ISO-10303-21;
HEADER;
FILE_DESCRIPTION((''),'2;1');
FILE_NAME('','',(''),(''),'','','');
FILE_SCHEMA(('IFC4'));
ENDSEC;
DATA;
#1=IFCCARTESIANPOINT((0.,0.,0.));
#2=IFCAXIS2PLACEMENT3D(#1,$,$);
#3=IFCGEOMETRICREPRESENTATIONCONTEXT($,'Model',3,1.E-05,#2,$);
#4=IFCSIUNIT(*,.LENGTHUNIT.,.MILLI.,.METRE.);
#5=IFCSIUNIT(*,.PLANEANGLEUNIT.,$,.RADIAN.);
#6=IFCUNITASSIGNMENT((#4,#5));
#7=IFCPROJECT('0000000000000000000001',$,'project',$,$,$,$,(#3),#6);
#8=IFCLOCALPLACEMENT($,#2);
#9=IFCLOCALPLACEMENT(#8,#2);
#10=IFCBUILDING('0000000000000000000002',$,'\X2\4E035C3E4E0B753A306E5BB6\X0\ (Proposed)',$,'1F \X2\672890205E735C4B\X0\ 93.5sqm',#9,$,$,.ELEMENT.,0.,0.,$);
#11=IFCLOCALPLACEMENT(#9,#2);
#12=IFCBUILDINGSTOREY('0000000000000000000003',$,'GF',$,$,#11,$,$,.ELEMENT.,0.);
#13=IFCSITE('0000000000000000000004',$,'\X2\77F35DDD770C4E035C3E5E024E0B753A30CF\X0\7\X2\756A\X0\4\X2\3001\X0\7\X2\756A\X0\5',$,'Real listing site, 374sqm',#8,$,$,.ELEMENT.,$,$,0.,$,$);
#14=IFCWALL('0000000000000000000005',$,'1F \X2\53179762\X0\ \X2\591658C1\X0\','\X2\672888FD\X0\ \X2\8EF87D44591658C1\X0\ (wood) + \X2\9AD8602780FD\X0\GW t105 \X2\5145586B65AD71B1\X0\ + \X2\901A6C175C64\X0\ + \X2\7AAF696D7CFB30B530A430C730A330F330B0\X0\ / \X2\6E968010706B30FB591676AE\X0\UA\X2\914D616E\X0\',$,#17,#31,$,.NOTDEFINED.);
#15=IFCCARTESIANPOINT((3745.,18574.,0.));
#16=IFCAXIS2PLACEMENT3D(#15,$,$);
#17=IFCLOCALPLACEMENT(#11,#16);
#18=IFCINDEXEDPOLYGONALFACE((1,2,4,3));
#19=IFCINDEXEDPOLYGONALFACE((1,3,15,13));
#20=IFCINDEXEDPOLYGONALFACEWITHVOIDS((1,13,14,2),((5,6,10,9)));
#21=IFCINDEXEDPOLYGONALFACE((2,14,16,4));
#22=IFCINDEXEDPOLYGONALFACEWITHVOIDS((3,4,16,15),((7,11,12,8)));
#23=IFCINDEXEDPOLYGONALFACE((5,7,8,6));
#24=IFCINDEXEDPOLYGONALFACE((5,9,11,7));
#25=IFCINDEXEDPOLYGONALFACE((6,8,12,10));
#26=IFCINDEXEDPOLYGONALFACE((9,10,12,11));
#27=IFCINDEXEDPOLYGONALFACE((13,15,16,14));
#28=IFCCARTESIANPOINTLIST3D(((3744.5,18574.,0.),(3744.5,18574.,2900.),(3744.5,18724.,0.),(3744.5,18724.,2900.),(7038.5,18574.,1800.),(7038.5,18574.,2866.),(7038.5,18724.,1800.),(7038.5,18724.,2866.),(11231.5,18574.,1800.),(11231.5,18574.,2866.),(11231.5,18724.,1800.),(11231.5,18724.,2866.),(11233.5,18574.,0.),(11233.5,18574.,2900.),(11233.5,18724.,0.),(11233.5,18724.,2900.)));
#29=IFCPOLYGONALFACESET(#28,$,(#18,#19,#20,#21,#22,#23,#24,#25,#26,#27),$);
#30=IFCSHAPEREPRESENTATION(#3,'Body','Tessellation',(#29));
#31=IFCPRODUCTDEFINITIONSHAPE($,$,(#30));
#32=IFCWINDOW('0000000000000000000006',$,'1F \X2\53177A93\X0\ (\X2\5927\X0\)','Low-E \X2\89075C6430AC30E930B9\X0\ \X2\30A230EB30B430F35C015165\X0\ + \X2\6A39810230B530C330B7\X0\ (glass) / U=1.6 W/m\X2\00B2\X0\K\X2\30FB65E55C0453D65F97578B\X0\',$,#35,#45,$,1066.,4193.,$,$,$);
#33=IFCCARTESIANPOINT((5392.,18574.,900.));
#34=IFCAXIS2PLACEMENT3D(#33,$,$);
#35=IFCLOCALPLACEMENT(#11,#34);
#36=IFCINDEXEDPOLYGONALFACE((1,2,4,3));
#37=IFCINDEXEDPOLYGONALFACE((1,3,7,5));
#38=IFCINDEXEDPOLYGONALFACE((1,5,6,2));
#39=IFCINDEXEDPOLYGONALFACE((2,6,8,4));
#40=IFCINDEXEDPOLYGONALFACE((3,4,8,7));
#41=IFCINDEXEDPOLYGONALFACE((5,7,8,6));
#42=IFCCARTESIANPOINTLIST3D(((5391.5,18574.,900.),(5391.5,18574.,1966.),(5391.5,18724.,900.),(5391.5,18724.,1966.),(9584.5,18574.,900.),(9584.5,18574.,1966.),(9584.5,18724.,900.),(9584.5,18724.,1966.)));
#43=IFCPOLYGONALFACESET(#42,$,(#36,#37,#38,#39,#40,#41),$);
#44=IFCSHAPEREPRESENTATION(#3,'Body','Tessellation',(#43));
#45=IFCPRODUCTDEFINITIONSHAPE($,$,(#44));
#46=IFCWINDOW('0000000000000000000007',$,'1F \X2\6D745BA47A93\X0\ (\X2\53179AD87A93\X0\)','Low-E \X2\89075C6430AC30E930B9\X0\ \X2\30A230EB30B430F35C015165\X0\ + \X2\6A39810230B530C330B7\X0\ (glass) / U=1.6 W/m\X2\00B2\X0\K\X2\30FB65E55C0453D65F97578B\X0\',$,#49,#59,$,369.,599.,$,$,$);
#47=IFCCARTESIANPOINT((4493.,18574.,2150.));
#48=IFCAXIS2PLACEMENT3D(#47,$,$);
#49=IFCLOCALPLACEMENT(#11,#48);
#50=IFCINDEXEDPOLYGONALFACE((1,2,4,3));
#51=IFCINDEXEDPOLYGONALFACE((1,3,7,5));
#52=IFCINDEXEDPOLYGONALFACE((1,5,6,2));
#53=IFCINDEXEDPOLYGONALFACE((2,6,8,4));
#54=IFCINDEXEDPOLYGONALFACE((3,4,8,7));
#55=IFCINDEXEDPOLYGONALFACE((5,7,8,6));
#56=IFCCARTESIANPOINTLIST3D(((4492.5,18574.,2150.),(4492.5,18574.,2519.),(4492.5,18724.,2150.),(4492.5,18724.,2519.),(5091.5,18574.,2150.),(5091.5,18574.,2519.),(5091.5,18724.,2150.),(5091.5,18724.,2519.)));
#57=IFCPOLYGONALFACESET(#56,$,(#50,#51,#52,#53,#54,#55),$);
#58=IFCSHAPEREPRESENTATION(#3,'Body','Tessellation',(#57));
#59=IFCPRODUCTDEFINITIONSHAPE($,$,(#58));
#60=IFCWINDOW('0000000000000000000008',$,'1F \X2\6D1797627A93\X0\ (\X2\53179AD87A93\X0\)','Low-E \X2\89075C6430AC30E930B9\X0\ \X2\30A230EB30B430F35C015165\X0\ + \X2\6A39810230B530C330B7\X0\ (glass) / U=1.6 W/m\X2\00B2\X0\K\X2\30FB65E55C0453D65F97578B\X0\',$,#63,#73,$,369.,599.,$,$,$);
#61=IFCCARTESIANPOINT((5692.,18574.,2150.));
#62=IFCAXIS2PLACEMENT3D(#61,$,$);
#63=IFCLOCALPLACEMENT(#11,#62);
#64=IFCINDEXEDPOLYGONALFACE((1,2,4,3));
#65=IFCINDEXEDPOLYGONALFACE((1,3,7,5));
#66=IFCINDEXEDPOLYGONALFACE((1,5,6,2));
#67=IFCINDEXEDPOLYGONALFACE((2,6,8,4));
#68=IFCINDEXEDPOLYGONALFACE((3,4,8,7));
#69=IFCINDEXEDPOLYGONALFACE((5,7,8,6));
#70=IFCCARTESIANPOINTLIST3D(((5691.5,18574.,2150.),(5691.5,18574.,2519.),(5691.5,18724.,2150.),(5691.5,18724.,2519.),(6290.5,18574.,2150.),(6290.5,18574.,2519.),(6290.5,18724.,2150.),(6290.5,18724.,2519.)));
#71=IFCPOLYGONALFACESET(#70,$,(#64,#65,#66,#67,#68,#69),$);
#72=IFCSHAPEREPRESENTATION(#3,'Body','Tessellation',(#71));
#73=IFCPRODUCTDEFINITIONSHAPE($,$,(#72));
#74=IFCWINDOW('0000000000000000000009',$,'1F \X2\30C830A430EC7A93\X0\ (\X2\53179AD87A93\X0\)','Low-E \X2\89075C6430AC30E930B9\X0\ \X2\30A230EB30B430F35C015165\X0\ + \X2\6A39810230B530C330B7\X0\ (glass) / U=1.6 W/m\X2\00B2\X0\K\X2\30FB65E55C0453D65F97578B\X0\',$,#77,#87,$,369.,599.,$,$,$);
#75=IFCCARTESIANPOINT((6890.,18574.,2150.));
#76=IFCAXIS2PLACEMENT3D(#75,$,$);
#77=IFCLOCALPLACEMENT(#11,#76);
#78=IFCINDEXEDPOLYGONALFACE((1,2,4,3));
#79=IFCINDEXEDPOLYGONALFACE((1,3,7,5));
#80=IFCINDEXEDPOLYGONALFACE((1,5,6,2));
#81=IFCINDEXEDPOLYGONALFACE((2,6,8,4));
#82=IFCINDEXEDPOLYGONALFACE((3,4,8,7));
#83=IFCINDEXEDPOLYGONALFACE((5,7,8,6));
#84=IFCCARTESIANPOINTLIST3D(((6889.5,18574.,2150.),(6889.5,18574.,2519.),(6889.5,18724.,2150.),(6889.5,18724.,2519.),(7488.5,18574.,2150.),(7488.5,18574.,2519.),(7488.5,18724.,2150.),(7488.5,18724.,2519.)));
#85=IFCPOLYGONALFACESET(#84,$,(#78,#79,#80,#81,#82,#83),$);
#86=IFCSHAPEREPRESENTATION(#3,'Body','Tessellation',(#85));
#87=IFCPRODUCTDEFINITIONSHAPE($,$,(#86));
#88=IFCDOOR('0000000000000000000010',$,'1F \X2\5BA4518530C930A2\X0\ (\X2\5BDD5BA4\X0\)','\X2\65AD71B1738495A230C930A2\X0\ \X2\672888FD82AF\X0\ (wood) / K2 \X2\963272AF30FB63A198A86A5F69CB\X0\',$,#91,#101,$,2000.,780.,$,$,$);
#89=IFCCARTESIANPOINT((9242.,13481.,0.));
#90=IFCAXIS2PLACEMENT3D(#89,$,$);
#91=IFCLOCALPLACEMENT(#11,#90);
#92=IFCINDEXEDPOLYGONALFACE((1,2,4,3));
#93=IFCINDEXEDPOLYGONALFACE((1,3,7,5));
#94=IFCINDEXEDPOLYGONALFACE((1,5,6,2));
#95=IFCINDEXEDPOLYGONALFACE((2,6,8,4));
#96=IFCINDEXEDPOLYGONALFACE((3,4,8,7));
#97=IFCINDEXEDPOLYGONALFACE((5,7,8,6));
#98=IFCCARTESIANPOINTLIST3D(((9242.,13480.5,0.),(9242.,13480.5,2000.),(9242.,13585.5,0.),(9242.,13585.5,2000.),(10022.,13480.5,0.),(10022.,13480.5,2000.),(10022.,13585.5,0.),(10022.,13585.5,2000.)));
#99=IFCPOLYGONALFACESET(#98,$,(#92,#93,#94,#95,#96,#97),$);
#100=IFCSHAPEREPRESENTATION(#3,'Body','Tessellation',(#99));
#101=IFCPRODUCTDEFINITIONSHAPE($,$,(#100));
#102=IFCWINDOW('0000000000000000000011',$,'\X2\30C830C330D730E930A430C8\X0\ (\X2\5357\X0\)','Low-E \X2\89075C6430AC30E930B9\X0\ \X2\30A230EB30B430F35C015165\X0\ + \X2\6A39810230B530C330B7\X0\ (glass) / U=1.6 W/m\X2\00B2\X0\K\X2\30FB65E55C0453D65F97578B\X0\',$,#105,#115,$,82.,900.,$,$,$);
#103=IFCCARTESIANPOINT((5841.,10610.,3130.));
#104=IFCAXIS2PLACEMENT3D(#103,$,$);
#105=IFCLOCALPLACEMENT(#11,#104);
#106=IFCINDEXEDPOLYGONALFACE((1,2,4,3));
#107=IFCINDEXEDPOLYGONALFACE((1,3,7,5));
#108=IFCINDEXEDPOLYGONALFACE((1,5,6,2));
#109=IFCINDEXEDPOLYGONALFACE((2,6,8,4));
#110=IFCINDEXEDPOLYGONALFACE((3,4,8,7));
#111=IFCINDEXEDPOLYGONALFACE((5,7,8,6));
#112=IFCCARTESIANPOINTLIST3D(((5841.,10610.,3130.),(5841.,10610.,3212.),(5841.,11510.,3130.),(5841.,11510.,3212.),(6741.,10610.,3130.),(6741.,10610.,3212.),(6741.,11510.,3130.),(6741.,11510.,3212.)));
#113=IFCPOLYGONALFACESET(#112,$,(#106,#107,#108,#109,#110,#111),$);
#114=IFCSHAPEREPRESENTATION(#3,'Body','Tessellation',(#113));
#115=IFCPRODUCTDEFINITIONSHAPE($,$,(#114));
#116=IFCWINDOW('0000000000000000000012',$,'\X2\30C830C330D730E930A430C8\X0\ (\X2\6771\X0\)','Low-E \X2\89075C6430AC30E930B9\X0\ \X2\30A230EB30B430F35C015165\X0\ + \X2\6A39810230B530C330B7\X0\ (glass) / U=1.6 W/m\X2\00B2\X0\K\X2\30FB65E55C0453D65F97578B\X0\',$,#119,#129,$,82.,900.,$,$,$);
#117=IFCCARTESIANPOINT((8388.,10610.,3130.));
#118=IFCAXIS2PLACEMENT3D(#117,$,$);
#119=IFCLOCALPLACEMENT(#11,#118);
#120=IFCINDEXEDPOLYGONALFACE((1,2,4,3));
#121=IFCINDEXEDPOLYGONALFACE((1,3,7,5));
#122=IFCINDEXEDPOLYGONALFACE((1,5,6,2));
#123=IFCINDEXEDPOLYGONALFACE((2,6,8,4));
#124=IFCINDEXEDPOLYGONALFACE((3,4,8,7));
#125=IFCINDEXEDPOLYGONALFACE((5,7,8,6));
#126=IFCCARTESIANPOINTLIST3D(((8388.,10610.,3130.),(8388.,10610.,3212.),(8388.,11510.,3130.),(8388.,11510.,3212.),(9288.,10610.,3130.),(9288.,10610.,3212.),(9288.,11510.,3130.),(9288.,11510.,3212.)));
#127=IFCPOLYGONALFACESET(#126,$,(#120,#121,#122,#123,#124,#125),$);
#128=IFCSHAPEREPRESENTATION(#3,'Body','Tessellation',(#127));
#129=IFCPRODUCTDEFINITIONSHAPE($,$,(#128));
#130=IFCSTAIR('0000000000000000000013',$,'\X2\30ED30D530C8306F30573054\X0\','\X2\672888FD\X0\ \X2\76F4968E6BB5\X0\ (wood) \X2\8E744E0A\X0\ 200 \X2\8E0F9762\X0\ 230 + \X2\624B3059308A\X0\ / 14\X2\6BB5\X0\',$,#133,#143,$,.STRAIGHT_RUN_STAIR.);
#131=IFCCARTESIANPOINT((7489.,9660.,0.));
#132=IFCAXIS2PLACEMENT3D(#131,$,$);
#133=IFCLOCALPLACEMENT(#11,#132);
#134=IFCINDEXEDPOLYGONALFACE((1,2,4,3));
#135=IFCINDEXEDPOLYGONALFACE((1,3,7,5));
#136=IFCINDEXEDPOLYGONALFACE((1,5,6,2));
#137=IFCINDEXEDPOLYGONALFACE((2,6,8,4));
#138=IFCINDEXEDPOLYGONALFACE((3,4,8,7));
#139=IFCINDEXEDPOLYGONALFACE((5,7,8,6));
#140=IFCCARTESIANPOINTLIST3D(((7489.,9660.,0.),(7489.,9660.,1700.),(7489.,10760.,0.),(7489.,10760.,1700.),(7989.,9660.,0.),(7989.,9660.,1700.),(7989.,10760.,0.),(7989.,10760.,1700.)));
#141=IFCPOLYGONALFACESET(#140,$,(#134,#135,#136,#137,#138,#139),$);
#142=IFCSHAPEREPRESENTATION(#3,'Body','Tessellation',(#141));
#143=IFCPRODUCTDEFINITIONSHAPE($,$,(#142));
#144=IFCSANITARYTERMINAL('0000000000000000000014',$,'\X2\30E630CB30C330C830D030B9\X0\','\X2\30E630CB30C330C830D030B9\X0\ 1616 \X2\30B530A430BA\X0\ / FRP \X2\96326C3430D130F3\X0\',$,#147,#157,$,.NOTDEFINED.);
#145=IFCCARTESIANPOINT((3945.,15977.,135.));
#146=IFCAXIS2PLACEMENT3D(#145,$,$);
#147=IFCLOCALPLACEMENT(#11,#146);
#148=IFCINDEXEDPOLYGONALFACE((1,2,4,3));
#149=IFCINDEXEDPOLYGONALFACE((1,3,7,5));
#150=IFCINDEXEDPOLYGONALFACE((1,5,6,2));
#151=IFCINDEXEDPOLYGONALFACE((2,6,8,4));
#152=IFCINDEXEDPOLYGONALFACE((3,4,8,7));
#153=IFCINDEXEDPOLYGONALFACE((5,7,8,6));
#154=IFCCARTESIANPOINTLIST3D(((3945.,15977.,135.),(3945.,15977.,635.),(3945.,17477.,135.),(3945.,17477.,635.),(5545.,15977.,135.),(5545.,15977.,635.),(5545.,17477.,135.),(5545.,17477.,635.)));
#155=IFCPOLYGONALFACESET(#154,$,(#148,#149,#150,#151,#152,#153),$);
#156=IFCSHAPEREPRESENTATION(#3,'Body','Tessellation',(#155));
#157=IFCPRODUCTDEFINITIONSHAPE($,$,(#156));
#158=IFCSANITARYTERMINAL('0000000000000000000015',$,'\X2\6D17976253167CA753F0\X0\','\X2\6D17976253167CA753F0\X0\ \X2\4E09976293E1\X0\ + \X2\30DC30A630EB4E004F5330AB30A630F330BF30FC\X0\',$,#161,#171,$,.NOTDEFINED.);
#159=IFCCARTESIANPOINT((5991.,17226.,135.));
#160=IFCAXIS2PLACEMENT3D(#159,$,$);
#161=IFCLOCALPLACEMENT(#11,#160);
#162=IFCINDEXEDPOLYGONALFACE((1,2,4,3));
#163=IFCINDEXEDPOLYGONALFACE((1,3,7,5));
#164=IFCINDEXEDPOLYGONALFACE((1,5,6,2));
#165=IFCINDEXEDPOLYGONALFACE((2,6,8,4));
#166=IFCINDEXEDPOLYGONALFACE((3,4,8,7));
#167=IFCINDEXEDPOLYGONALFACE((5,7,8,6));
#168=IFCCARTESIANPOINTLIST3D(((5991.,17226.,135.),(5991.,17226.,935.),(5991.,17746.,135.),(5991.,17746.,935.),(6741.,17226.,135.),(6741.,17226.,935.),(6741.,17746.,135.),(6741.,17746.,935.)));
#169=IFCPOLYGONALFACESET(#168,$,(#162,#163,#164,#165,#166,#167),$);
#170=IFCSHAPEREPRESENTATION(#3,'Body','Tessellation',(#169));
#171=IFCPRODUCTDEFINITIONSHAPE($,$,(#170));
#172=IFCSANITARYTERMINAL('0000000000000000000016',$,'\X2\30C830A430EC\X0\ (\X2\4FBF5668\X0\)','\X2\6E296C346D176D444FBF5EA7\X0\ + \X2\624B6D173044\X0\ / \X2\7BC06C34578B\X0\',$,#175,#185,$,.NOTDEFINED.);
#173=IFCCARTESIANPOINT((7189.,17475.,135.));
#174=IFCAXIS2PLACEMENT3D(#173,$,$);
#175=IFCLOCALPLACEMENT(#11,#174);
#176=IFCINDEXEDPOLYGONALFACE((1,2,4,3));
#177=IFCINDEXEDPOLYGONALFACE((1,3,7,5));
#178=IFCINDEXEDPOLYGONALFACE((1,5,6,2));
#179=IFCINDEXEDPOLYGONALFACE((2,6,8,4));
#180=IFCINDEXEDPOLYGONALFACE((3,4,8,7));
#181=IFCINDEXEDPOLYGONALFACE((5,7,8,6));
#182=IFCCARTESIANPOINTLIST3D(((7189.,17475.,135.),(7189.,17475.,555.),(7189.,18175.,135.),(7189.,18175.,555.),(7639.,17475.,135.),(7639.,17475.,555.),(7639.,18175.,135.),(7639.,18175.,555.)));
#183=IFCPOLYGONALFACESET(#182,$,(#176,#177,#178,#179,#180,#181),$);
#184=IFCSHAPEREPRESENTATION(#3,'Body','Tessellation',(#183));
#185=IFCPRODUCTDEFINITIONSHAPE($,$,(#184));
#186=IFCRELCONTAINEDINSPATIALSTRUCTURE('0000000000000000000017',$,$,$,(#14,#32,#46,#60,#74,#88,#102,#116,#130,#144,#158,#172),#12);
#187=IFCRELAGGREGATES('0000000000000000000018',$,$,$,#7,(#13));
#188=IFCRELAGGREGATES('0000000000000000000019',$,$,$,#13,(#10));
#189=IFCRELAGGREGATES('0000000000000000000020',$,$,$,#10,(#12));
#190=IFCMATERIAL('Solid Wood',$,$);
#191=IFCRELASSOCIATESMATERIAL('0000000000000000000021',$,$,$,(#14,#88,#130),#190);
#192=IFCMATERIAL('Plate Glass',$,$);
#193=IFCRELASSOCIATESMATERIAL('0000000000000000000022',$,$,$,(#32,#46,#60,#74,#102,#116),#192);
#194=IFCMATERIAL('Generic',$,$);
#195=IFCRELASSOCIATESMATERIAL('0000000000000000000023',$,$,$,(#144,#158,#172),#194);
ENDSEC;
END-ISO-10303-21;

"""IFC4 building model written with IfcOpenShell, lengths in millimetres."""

from ifc_helpers import new_model, si_unit, frame, frame_2d, origin, place, context, project, spatial, rectangle, extrude, material, element, fill, save


model = new_model("IFC4")

# Units and contexts
model_context = context("Model", 3, precision=1e-05, world=origin())
ifc_project = project(units=[si_unit("LENGTHUNIT", "METRE", prefix="MILLI"), si_unit("PLANEANGLEUNIT", "RADIAN")], contexts=[model_context])

# Site, building, storey
site_placement = place(None, origin())
site = spatial("IfcSite", under=ifc_project, at=site_placement, Name="石川県七尾市下町ハ7番4、7番5", ObjectType="Real listing site, 374sqm", CompositionType="ELEMENT", RefElevation=0.0)
building_placement = place(site_placement, origin())
building = spatial("IfcBuilding", under=site, at=building_placement, Name="七尾下町の家 (Proposed)", ObjectType="1F 木造平屋 93.5sqm", CompositionType="ELEMENT", ElevationOfRefHeight=0.0, ElevationOfTerrain=0.0)
storey_placement = place(building_placement, origin())
storey = spatial("IfcBuildingStorey", under=building, at=storey_placement, Name="GF", CompositionType="ELEMENT", Elevation=0.0)

# Shared definitions
ifc_material_1 = material(Name="Solid Wood")

# Wall, openings, windows
wall_1_placement = place(storey_placement, frame((3745.0, 18574.0, 0.0)))
wall_1 = element("IfcWall", 1, at=wall_1_placement, inside=storey, material=ifc_material_1, Name="1F 北面 外壁", Description="木製 軸組外壁 (wood) + 高性能GW t105 充填断熱 + 通気層 + 窯業系サイディング / 準耐火・外皮UA配慮", PredefinedType="NOTDEFINED", context=model_context, shape_type="SweptSolid", body=[
    extrude(rectangle(XDim=7489.0, YDim=150.0, at=frame_2d((3744.0, 75.0))), frame((3745.0, 18574.0, 0.0)), (0.0, 0.0, 1.0), 2900.0),
])
opening_1_placement = place(storey_placement, frame((5392.0, 18574.0, 900.0)))
opening_1 = element("IfcOpeningElement", 2, at=opening_1_placement, cuts=wall_1, PredefinedType="NOTDEFINED", context=model_context, shape_type="SweptSolid", body=[
    extrude(rectangle(XDim=4193.0, YDim=150.0, at=frame_2d((2096.0, 75.0))), frame((5392.0, 18574.0, 900.0)), (0.0, 0.0, 1.0), 1066.0),
])
opening_2_placement = place(storey_placement, frame((4493.0, 18574.0, 2150.0)))
opening_2 = element("IfcOpeningElement", 3, at=opening_2_placement, cuts=wall_1, PredefinedType="NOTDEFINED", context=model_context, shape_type="SweptSolid", body=[
    extrude(rectangle(XDim=599.0, YDim=150.0, at=frame_2d((299.0, 75.0))), frame((4493.0, 18574.0, 2150.0)), (0.0, 0.0, 1.0), 369.0),
])
opening_3_placement = place(storey_placement, frame((5692.0, 18574.0, 2150.0)))
opening_3 = element("IfcOpeningElement", 4, at=opening_3_placement, cuts=wall_1, PredefinedType="NOTDEFINED", context=model_context, shape_type="SweptSolid", body=[
    extrude(rectangle(XDim=599.0, YDim=150.0, at=frame_2d((299.0, 75.0))), frame((5692.0, 18574.0, 2150.0)), (0.0, 0.0, 1.0), 369.0),
])
opening_4_placement = place(storey_placement, frame((6890.0, 18574.0, 2150.0)))
opening_4 = element("IfcOpeningElement", 5, at=opening_4_placement, cuts=wall_1, PredefinedType="NOTDEFINED", context=model_context, shape_type="SweptSolid", body=[
    extrude(rectangle(XDim=599.0, YDim=150.0, at=frame_2d((299.0, 75.0))), frame((6890.0, 18574.0, 2150.0)), (0.0, 0.0, 1.0), 369.0),
])
ifc_material_2 = material(Name="Plate Glass")
window_1_placement = place(storey_placement, frame((5392.0, 18574.0, 900.0)))
window_1 = element("IfcWindow", 6, at=window_1_placement, inside=storey, material=ifc_material_2, Name="1F 北窓 (大)", Description="Low-E 複層ガラス アルゴン封入 + 樹脂サッシ (glass) / U=1.6 W/m²K・日射取得型", OverallHeight=1066.0, OverallWidth=4193.0, context=model_context, shape_type="SweptSolid", body=[
    extrude(rectangle(XDim=4193.0, YDim=150.0, at=frame_2d((2096.0, 75.0))), frame((5392.0, 18574.0, 900.0)), (0.0, 0.0, 1.0), 1066.0),
])
fill(opening_1, window_1)
window_2_placement = place(storey_placement, frame((4493.0, 18574.0, 2150.0)))
window_2 = element("IfcWindow", 7, at=window_2_placement, inside=storey, material=ifc_material_2, Name="1F 浴室窓 (北高窓)", Description="Low-E 複層ガラス アルゴン封入 + 樹脂サッシ (glass) / U=1.6 W/m²K・日射取得型", OverallHeight=369.0, OverallWidth=599.0, context=model_context, shape_type="SweptSolid", body=[
    extrude(rectangle(XDim=599.0, YDim=150.0, at=frame_2d((299.0, 75.0))), frame((4493.0, 18574.0, 2150.0)), (0.0, 0.0, 1.0), 369.0),
])
fill(opening_2, window_2)
window_3_placement = place(storey_placement, frame((5692.0, 18574.0, 2150.0)))
window_3 = element("IfcWindow", 8, at=window_3_placement, inside=storey, material=ifc_material_2, Name="1F 洗面窓 (北高窓)", Description="Low-E 複層ガラス アルゴン封入 + 樹脂サッシ (glass) / U=1.6 W/m²K・日射取得型", OverallHeight=369.0, OverallWidth=599.0, context=model_context, shape_type="SweptSolid", body=[
    extrude(rectangle(XDim=599.0, YDim=150.0, at=frame_2d((299.0, 75.0))), frame((5692.0, 18574.0, 2150.0)), (0.0, 0.0, 1.0), 369.0),
])
fill(opening_3, window_3)
window_4_placement = place(storey_placement, frame((6890.0, 18574.0, 2150.0)))
window_4 = element("IfcWindow", 9, at=window_4_placement, inside=storey, material=ifc_material_2, Name="1F トイレ窓 (北高窓)", Description="Low-E 複層ガラス アルゴン封入 + 樹脂サッシ (glass) / U=1.6 W/m²K・日射取得型", OverallHeight=369.0, OverallWidth=599.0, context=model_context, shape_type="SweptSolid", body=[
    extrude(rectangle(XDim=599.0, YDim=150.0, at=frame_2d((299.0, 75.0))), frame((6890.0, 18574.0, 2150.0)), (0.0, 0.0, 1.0), 369.0),
])
fill(opening_4, window_4)

# Door
door_1_placement = place(storey_placement, frame((9242.0, 13481.0, 0.0)))
element("IfcDoor", 10, at=door_1_placement, inside=storey, material=ifc_material_1, Name="1F 室内ドア (寝室)", Description="断熱玄関ドア 木製芯 (wood) / K2 防犯・採風機構", OverallHeight=2000.0, OverallWidth=780.0, context=model_context, shape_type="SweptSolid", body=[
    extrude(rectangle(XDim=780.0, YDim=105.0, at=frame_2d((390.0, 52.0))), frame((9242.0, 13481.0, 0.0)), (0.0, 0.0, 1.0), 2000.0),
])

# Windows
window_5_placement = place(storey_placement, frame((5841.0, 10610.0, 3130.0)))
element("IfcWindow", 11, at=window_5_placement, inside=storey, material=ifc_material_2, Name="トップライト (南)", Description="Low-E 複層ガラス アルゴン封入 + 樹脂サッシ (glass) / U=1.6 W/m²K・日射取得型", OverallHeight=82.0, OverallWidth=900.0, context=model_context, shape_type="SweptSolid", body=[
    extrude(rectangle(XDim=900.0, YDim=900.0, at=frame_2d((450.0, 450.0))), frame((5841.0, 10610.0, 3130.0)), (0.0, 0.0, 1.0), 82.0),
])
window_6_placement = place(storey_placement, frame((8388.0, 10610.0, 3130.0)))
element("IfcWindow", 12, at=window_6_placement, inside=storey, material=ifc_material_2, Name="トップライト (東)", Description="Low-E 複層ガラス アルゴン封入 + 樹脂サッシ (glass) / U=1.6 W/m²K・日射取得型", OverallHeight=82.0, OverallWidth=900.0, context=model_context, shape_type="SweptSolid", body=[
    extrude(rectangle(XDim=900.0, YDim=900.0, at=frame_2d((450.0, 450.0))), frame((8388.0, 10610.0, 3130.0)), (0.0, 0.0, 1.0), 82.0),
])

# Stair
stair_placement = place(storey_placement, frame((7489.0, 9660.0, 0.0)))
element("IfcStair", 13, at=stair_placement, inside=storey, material=ifc_material_1, Name="ロフトはしご", Description="木製 直階段 (wood) 蹴上 200 踏面 230 + 手すり / 14段", PredefinedType="STRAIGHT_RUN_STAIR", context=model_context, shape_type="SweptSolid", body=[
    extrude(rectangle(XDim=500.0, YDim=1100.0, at=frame_2d((250.0, 550.0))), frame((7489.0, 9660.0, 0.0)), (0.0, 0.0, 1.0), 1700.0),
])

# Sanitary terminals
ifc_material_3 = material(Name="Generic")
sanitary_terminal_1_placement = place(storey_placement, frame((3945.0, 15977.0, 135.0)))
element("IfcSanitaryTerminal", 14, at=sanitary_terminal_1_placement, inside=storey, material=ifc_material_3, Name="ユニットバス", Description="ユニットバス 1616 サイズ / FRP 防水パン", PredefinedType="NOTDEFINED", context=model_context, shape_type="SweptSolid", body=[
    extrude(rectangle(XDim=1600.0, YDim=1500.0, at=frame_2d((800.0, 750.0))), frame((3945.0, 15977.0, 135.0)), (0.0, 0.0, 1.0), 500.0),
])
sanitary_terminal_2_placement = place(storey_placement, frame((5991.0, 17226.0, 135.0)))
element("IfcSanitaryTerminal", 15, at=sanitary_terminal_2_placement, inside=storey, material=ifc_material_3, Name="洗面化粧台", Description="洗面化粧台 三面鏡 + ボウル一体カウンター", PredefinedType="NOTDEFINED", context=model_context, shape_type="SweptSolid", body=[
    extrude(rectangle(XDim=750.0, YDim=520.0, at=frame_2d((375.0, 260.0))), frame((5991.0, 17226.0, 135.0)), (0.0, 0.0, 1.0), 800.0),
])
sanitary_terminal_3_placement = place(storey_placement, frame((7189.0, 17475.0, 135.0)))
element("IfcSanitaryTerminal", 16, at=sanitary_terminal_3_placement, inside=storey, material=ifc_material_3, Name="トイレ (便器)", Description="温水洗浄便座 + 手洗い / 節水型", PredefinedType="NOTDEFINED", context=model_context, shape_type="SweptSolid", body=[
    extrude(rectangle(XDim=450.0, YDim=700.0, at=frame_2d((225.0, 350.0))), frame((7189.0, 17475.0, 135.0)), (0.0, 0.0, 1.0), 420.0),
])

save(model, "model.ifc")
